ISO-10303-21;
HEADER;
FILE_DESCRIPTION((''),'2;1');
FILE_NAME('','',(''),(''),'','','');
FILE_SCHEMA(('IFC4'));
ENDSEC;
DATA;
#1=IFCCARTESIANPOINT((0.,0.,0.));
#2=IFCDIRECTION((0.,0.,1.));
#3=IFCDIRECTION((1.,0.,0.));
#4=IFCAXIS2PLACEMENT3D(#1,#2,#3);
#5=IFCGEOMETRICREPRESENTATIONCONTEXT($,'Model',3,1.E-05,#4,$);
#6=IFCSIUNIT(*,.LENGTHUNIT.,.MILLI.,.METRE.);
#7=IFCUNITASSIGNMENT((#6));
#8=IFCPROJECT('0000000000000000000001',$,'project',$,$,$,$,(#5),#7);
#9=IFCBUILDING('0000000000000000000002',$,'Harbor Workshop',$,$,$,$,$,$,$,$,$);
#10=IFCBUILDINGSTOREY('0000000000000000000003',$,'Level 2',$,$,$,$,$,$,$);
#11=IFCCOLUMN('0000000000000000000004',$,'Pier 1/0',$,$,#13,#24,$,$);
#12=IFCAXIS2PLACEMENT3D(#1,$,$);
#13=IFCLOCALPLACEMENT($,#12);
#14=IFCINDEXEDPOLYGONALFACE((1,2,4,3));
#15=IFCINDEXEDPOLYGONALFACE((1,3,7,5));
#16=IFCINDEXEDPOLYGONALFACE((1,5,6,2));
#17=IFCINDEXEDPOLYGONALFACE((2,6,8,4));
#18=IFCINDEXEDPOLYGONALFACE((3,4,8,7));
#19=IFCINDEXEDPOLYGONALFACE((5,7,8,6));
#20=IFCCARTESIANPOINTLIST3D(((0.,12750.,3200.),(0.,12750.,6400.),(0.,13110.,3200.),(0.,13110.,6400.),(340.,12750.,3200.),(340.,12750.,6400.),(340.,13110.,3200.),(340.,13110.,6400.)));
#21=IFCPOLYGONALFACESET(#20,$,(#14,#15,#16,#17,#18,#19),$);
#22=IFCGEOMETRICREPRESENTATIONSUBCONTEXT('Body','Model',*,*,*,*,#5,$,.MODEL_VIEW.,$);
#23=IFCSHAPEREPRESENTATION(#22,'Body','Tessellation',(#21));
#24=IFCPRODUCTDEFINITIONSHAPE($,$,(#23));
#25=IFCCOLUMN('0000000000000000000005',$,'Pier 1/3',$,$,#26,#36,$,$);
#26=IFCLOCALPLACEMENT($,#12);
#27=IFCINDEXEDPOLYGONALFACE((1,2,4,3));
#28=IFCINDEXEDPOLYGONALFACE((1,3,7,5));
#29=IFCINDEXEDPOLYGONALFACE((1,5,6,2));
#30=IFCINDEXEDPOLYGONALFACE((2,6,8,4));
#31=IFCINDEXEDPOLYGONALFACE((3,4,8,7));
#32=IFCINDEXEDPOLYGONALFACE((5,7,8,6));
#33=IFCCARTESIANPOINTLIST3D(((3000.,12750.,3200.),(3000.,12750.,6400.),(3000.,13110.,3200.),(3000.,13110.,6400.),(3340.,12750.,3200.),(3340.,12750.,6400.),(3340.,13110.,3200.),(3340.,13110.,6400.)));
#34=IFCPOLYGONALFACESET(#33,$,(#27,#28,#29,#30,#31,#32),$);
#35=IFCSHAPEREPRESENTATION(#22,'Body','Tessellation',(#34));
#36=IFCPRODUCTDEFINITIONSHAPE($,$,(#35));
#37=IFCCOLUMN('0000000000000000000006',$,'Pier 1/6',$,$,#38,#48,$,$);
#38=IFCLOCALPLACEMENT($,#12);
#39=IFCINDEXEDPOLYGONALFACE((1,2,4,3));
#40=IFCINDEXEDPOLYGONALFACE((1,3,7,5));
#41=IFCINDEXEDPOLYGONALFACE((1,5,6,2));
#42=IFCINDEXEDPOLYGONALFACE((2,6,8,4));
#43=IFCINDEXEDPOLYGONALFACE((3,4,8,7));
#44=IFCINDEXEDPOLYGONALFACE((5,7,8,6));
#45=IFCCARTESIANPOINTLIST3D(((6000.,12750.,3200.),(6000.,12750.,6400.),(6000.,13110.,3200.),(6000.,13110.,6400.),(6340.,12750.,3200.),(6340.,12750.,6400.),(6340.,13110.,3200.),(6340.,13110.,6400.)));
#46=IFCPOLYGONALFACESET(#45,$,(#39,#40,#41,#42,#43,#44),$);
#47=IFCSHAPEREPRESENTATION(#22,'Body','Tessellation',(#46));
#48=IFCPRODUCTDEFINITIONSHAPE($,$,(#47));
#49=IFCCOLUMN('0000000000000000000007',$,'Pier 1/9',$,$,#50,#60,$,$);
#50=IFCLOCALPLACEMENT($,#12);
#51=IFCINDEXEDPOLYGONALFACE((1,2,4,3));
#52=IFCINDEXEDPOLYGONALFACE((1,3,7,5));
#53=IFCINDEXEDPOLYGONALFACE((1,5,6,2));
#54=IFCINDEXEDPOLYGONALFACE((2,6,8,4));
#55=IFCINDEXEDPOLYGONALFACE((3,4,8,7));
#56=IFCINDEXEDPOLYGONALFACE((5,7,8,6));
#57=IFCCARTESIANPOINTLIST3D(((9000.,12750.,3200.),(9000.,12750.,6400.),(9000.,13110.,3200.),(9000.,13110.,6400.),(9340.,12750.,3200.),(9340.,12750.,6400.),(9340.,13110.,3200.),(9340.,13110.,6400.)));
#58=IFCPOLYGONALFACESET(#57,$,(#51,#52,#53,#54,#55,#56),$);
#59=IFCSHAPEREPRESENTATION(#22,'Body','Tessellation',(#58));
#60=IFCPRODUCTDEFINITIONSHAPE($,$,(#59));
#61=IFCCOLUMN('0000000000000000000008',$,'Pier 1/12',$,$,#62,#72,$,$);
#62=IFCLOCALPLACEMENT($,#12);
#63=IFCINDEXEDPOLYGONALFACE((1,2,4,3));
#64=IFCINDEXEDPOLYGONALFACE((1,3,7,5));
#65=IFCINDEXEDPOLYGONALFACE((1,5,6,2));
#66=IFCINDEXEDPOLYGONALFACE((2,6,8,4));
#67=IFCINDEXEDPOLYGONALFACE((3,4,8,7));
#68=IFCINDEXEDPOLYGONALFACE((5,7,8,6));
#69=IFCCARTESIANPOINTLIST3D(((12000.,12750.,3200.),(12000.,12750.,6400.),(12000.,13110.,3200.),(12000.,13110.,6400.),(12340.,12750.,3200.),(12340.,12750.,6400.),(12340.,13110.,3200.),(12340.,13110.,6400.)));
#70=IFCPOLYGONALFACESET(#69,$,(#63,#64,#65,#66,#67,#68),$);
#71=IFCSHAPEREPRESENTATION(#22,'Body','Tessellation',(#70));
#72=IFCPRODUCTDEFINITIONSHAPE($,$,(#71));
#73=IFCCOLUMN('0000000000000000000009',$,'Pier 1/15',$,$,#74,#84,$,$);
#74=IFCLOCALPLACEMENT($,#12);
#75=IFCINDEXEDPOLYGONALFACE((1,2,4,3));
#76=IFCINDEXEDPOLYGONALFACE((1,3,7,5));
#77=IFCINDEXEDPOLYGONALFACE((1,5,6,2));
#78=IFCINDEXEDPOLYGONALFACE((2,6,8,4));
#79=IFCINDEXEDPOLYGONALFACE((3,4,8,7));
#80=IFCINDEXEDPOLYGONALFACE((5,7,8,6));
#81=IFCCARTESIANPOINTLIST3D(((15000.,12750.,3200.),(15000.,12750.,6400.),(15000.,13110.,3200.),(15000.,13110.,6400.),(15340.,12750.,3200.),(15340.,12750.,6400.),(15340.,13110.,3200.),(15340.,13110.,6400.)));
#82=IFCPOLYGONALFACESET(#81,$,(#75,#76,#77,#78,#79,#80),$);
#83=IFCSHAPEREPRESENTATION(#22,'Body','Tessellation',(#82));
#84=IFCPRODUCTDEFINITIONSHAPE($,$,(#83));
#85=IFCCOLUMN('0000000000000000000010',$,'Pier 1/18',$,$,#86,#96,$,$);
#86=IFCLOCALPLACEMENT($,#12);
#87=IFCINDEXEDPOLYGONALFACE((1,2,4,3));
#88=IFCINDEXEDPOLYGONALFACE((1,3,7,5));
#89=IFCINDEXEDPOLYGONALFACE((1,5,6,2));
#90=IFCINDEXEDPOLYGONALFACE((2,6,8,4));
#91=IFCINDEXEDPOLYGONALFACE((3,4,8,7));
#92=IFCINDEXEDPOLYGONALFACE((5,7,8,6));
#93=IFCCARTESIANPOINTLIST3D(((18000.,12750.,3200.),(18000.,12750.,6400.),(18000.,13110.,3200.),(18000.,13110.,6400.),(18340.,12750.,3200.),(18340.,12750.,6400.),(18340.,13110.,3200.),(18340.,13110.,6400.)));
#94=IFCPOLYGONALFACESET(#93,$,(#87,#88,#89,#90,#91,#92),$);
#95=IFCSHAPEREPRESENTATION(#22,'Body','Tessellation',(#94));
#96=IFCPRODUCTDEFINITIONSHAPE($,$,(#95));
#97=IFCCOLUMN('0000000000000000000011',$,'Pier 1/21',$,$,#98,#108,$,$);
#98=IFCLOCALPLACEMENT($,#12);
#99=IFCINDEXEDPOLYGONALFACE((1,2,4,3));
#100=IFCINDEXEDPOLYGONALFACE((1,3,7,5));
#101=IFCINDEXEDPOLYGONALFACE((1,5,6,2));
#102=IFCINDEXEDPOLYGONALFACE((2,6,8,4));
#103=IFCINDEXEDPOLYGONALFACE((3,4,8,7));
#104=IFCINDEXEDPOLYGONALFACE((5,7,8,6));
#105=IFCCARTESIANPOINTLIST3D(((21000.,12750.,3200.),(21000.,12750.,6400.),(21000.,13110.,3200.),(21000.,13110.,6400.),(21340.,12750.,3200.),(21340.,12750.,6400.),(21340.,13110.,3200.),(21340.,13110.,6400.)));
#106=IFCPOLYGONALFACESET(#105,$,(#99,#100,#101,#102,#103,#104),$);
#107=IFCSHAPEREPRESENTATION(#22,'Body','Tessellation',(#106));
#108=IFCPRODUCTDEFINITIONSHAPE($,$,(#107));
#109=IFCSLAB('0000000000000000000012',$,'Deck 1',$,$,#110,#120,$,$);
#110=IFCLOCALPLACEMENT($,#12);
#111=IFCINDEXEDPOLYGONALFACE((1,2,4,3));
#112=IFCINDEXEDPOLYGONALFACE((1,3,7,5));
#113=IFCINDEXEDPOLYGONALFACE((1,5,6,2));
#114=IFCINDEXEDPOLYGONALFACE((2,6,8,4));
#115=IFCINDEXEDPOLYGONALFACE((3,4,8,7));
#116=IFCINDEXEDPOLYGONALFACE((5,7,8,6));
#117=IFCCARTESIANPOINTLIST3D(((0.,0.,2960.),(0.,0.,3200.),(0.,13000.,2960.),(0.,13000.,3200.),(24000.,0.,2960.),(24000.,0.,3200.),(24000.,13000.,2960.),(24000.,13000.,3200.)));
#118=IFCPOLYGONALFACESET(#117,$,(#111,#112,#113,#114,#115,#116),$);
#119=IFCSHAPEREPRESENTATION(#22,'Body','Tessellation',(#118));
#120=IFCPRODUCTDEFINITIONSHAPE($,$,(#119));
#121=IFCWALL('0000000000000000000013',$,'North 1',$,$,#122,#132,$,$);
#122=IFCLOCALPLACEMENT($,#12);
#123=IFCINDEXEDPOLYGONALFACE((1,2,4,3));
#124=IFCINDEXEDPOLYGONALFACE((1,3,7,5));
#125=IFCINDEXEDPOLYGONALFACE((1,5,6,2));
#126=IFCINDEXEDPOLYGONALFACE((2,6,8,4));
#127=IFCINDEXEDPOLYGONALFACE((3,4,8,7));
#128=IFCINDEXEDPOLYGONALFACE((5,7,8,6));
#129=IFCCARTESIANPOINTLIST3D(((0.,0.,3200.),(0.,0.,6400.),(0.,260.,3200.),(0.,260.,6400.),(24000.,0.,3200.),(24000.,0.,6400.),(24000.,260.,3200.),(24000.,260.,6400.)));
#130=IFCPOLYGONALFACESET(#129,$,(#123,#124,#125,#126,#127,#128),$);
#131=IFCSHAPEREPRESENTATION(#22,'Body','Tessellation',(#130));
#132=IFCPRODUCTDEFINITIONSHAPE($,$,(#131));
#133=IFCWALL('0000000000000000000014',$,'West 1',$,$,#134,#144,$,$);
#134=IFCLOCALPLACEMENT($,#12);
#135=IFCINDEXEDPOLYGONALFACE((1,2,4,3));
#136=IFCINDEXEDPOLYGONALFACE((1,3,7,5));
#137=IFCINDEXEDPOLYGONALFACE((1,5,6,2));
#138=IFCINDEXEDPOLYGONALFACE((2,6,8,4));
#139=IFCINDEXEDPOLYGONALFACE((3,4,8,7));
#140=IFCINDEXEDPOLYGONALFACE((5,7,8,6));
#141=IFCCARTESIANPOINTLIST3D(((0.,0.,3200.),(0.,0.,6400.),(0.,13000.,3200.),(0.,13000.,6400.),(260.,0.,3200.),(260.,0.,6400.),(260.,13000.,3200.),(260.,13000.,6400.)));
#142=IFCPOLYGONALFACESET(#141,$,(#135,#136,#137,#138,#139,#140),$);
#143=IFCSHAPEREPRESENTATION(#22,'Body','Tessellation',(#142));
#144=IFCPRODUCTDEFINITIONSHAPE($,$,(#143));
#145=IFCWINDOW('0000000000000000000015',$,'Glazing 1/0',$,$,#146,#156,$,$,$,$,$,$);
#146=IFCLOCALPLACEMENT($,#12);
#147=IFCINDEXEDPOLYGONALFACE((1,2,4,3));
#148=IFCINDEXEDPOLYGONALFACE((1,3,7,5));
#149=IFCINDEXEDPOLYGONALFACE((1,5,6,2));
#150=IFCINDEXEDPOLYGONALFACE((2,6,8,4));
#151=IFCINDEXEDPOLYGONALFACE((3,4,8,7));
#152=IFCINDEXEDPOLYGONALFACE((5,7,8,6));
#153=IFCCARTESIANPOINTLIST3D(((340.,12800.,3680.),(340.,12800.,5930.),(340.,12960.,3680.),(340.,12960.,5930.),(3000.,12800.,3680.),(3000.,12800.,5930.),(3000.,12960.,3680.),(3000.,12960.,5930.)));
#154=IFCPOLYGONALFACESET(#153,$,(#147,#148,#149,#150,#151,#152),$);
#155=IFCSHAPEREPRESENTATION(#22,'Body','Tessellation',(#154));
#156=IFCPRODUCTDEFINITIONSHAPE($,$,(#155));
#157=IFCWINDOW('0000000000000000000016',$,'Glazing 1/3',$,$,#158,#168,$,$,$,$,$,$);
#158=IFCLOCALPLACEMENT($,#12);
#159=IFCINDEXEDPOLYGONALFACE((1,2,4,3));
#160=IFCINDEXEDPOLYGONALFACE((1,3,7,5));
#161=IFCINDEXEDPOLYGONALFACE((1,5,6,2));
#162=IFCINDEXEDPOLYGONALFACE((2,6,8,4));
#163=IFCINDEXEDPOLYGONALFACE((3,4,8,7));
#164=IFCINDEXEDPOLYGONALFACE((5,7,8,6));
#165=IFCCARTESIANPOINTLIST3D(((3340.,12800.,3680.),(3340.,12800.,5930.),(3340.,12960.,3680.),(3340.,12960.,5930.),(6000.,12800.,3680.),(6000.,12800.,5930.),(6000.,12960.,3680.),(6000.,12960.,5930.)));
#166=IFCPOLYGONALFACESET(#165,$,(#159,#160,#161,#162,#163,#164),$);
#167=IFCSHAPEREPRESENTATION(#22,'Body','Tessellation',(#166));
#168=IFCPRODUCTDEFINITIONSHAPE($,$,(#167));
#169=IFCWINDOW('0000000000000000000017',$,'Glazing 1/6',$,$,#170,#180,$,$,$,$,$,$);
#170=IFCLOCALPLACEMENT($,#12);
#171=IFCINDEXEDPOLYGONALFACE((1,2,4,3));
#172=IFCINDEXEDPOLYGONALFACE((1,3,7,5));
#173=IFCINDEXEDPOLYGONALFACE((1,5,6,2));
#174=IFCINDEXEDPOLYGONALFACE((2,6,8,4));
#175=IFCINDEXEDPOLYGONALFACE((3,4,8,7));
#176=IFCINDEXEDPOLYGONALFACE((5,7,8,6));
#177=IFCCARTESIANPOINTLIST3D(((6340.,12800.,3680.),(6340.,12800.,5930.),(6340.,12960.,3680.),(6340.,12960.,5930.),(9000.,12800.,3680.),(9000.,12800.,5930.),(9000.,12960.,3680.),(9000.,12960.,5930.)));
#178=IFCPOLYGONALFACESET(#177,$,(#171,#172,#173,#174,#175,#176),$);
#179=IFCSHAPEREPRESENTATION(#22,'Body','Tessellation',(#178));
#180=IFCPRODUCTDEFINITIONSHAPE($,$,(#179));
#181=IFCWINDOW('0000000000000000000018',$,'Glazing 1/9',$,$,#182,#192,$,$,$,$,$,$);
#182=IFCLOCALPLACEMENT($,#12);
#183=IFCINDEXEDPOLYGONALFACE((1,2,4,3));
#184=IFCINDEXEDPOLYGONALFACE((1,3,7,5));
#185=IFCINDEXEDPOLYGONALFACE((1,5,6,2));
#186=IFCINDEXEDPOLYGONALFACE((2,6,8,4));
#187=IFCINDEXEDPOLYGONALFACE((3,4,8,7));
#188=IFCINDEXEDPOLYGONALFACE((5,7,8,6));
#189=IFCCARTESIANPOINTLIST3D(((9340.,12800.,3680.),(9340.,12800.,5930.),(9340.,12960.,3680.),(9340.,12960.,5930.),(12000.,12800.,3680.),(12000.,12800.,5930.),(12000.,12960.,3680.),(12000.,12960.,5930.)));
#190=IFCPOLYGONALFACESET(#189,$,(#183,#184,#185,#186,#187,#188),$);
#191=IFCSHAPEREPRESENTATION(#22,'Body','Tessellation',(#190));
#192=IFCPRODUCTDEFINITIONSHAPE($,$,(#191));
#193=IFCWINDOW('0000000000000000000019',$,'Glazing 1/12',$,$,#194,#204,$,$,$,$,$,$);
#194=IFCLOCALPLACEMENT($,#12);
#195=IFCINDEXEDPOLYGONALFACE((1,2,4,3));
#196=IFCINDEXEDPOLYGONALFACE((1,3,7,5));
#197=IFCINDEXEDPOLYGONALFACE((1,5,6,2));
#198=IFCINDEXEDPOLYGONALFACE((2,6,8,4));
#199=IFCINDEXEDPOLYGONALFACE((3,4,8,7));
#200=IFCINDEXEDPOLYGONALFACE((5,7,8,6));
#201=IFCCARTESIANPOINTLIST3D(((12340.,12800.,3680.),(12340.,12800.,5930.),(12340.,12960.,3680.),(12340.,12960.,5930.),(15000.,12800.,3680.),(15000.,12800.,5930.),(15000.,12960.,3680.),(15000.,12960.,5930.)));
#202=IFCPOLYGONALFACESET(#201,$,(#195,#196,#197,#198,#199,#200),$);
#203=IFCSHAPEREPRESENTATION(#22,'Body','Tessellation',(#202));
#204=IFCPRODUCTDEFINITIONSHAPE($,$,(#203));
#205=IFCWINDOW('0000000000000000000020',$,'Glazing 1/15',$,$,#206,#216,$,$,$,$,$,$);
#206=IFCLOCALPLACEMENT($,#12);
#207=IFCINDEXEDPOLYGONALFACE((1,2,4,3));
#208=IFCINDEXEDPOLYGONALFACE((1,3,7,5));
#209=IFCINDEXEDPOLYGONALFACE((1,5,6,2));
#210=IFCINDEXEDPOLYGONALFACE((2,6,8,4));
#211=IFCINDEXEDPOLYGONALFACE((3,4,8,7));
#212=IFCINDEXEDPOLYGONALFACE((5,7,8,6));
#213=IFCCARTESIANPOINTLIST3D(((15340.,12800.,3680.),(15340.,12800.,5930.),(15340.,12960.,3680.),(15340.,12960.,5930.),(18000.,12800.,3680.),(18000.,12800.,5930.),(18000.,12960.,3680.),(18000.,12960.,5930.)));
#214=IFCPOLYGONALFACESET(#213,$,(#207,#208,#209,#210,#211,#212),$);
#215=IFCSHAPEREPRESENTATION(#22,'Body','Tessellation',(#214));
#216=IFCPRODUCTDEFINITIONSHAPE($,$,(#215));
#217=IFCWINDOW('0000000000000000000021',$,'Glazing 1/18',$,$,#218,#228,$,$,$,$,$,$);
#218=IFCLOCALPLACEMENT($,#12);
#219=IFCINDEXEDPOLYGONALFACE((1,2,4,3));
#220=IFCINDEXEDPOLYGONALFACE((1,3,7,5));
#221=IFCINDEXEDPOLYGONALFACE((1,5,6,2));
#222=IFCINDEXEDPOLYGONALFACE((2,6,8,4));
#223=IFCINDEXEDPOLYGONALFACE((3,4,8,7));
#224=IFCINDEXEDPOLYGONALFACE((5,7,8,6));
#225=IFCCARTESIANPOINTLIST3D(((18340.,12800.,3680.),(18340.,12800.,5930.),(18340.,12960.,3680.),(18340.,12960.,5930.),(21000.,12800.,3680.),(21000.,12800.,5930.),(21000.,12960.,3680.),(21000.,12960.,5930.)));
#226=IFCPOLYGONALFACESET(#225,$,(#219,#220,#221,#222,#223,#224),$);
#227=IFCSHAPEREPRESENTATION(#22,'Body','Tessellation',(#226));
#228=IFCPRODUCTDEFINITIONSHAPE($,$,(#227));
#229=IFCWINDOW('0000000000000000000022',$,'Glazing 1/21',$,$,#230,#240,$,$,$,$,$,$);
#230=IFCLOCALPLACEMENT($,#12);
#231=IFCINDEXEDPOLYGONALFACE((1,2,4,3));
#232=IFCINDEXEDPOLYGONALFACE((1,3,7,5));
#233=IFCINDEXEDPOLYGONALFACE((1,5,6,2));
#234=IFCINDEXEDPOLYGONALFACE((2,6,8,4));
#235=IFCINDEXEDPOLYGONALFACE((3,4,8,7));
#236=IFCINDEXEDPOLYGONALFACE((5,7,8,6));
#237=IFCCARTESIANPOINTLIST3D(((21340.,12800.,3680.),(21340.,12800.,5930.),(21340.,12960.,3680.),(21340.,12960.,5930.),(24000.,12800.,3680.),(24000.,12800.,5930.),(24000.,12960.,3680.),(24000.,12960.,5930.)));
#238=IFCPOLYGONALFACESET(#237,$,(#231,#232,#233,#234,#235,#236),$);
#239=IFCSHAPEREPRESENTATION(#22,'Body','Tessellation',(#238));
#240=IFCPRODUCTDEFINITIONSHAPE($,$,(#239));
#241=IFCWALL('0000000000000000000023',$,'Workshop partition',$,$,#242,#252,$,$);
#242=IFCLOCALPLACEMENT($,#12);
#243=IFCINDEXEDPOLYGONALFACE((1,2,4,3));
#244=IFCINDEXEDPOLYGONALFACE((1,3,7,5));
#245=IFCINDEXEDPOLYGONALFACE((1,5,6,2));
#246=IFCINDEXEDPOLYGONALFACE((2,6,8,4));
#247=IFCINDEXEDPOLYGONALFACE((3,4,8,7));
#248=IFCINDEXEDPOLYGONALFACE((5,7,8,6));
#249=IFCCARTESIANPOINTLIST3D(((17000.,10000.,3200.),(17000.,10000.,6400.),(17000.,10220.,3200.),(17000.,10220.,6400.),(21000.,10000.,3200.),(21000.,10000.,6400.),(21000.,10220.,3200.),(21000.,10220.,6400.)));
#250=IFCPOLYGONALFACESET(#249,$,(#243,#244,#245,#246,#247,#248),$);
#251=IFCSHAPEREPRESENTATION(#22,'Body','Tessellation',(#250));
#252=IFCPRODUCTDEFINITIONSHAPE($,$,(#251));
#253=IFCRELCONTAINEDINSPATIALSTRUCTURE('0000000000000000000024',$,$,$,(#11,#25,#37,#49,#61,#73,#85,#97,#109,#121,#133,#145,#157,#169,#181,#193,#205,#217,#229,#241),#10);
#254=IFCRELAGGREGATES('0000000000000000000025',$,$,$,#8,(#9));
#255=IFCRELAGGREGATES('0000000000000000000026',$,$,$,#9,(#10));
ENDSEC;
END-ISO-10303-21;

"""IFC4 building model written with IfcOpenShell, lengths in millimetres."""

from ifc_helpers import new_model, si_unit, frame, origin_with_axes, place, context, subcontext, project, spatial, indexed_curve, outline, extrude, element, save


model = new_model("IFC4")

# Units and contexts
model_context = context("Model", 3, precision=1e-05, world=origin_with_axes())
body_context = subcontext(model_context, "Body", "Model", "MODEL_VIEW")
ifc_project = project(units=[si_unit("LENGTHUNIT", "METRE", prefix="MILLI")], contexts=[model_context])

# Building, storey
building = spatial("IfcBuilding", under=ifc_project, Name="Harbor Workshop")
storey = spatial("IfcBuildingStorey", under=building, Name="Level 2")

# Columns
for number, where, z_axis, x_axis, name in (
    (1, (0.0, 12750.0, 3200.0), (0.0, 0.0, 1.0), (1.0, 0.0, 0.0), "Pier 1/0"),
    (2, (3000.0, 12750.0, 3200.0), (0.0, 0.0, 1.0), (1.0, 0.0, 0.0), "Pier 1/3"),
    (3, (6000.0, 12750.0, 3200.0), (0.0, 0.0, 1.0), (1.0, 0.0, 0.0), "Pier 1/6"),
    (4, (9000.0, 12750.0, 3200.0), (0.0, 0.0, 1.0), (1.0, 0.0, 0.0), "Pier 1/9"),
    (5, (12000.0, 12750.0, 3200.0), (0.0, 0.0, 1.0), (1.0, 0.0, 0.0), "Pier 1/12"),
    (6, (15000.0, 12750.0, 3200.0), (0.0, 0.0, 1.0), (1.0, 0.0, 0.0), "Pier 1/15"),
    (7, (18000.0, 12750.0, 3200.0), (0.0, 0.0, 1.0), (1.0, 0.0, 0.0), "Pier 1/18"),
    (8, (21000.0, 12750.0, 3200.0), (0.0, 0.0, 1.0), (1.0, 0.0, 0.0), "Pier 1/21"),
):
    element("IfcColumn", number, at=place(None, frame(where, z_axis=z_axis, x_axis=x_axis)), inside=storey, Name=name, context=body_context, shape_type="SweptSolid", body=[
        extrude(outline(indexed_curve([(0.0, 0.0), (0.0, 360.0), (340.0, 360.0), (340.0, 0.0), (0.0, 0.0)], self_intersect=False)), origin_with_axes(), (0.0, 0.0, 1.0), 3200.0),
    ])

# Slab
slab_placement = place(None, frame((0.0, 0.0, 2960.0), z_axis=(0.0, 0.0, 1.0), x_axis=(1.0, 0.0, 0.0)))
element("IfcSlab", 9, at=slab_placement, inside=storey, Name="Deck 1", context=body_context, shape_type="SweptSolid", body=[
    extrude(outline(indexed_curve([(0.0, 0.0), (0.0, 13000.0), (24000.0, 13000.0), (24000.0, 0.0), (0.0, 0.0)], self_intersect=False)), origin_with_axes(), (0.0, 0.0, 1.0), 240.0),
])

# Walls
wall_1_placement = place(None, frame((0.0, 0.0, 3200.0), z_axis=(0.0, 0.0, 1.0), x_axis=(1.0, 0.0, 0.0)))
element("IfcWall", 10, at=wall_1_placement, inside=storey, Name="North 1", context=body_context, shape_type="SweptSolid", body=[
    extrude(outline(indexed_curve([(0.0, 0.0), (0.0, 260.0), (24000.0, 260.0), (24000.0, 0.0), (0.0, 0.0)], self_intersect=False)), origin_with_axes(), (0.0, 0.0, 1.0), 3200.0),
])
wall_2_placement = place(None, frame((260.0, 0.0, 3200.0), z_axis=(0.0, 0.0, 1.0), x_axis=(0.0, 1.0, 0.0)))
element("IfcWall", 11, at=wall_2_placement, inside=storey, Name="West 1", context=body_context, shape_type="SweptSolid", body=[
    extrude(outline(indexed_curve([(0.0, 0.0), (0.0, 260.0), (13000.0, 260.0), (13000.0, 0.0), (0.0, 0.0)], self_intersect=False)), origin_with_axes(), (0.0, 0.0, 1.0), 3200.0),
])

# Windows
for number, where, z_axis, x_axis, name in (
    (12, (340.0, 12800.0, 3680.0), (0.0, 0.0, 1.0), (1.0, 0.0, 0.0), "Glazing 1/0"),
    (13, (3340.0, 12800.0, 3680.0), (0.0, 0.0, 1.0), (1.0, 0.0, 0.0), "Glazing 1/3"),
    (14, (6340.0, 12800.0, 3680.0), (0.0, 0.0, 1.0), (1.0, 0.0, 0.0), "Glazing 1/6"),
    (15, (9340.0, 12800.0, 3680.0), (0.0, 0.0, 1.0), (1.0, 0.0, 0.0), "Glazing 1/9"),
    (16, (12340.0, 12800.0, 3680.0), (0.0, 0.0, 1.0), (1.0, 0.0, 0.0), "Glazing 1/12"),
    (17, (15340.0, 12800.0, 3680.0), (0.0, 0.0, 1.0), (1.0, 0.0, 0.0), "Glazing 1/15"),
    (18, (18340.0, 12800.0, 3680.0), (0.0, 0.0, 1.0), (1.0, 0.0, 0.0), "Glazing 1/18"),
    (19, (21340.0, 12800.0, 3680.0), (0.0, 0.0, 1.0), (1.0, 0.0, 0.0), "Glazing 1/21"),
):
    element("IfcWindow", number, at=place(None, frame(where, z_axis=z_axis, x_axis=x_axis)), inside=storey, Name=name, context=body_context, shape_type="SweptSolid", body=[
        extrude(outline(indexed_curve([(0.0, 0.0), (0.0, 160.0), (2660.0, 160.0), (2660.0, 0.0), (0.0, 0.0)], self_intersect=False)), origin_with_axes(), (0.0, 0.0, 1.0), 2250.0),
    ])

# Wall
wall_3_placement = place(None, frame((17000.0, 10000.0, 3200.0), z_axis=(0.0, 0.0, 1.0), x_axis=(1.0, 0.0, 0.0)))
element("IfcWall", 20, at=wall_3_placement, inside=storey, Name="Workshop partition", context=body_context, shape_type="SweptSolid", body=[
    extrude(outline(indexed_curve([(0.0, 0.0), (0.0, 220.0), (4000.0, 220.0), (4000.0, 0.0), (0.0, 0.0)], self_intersect=False)), origin_with_axes(), (0.0, 0.0, 1.0), 3200.0),
])

save(model, "model.ifc")
